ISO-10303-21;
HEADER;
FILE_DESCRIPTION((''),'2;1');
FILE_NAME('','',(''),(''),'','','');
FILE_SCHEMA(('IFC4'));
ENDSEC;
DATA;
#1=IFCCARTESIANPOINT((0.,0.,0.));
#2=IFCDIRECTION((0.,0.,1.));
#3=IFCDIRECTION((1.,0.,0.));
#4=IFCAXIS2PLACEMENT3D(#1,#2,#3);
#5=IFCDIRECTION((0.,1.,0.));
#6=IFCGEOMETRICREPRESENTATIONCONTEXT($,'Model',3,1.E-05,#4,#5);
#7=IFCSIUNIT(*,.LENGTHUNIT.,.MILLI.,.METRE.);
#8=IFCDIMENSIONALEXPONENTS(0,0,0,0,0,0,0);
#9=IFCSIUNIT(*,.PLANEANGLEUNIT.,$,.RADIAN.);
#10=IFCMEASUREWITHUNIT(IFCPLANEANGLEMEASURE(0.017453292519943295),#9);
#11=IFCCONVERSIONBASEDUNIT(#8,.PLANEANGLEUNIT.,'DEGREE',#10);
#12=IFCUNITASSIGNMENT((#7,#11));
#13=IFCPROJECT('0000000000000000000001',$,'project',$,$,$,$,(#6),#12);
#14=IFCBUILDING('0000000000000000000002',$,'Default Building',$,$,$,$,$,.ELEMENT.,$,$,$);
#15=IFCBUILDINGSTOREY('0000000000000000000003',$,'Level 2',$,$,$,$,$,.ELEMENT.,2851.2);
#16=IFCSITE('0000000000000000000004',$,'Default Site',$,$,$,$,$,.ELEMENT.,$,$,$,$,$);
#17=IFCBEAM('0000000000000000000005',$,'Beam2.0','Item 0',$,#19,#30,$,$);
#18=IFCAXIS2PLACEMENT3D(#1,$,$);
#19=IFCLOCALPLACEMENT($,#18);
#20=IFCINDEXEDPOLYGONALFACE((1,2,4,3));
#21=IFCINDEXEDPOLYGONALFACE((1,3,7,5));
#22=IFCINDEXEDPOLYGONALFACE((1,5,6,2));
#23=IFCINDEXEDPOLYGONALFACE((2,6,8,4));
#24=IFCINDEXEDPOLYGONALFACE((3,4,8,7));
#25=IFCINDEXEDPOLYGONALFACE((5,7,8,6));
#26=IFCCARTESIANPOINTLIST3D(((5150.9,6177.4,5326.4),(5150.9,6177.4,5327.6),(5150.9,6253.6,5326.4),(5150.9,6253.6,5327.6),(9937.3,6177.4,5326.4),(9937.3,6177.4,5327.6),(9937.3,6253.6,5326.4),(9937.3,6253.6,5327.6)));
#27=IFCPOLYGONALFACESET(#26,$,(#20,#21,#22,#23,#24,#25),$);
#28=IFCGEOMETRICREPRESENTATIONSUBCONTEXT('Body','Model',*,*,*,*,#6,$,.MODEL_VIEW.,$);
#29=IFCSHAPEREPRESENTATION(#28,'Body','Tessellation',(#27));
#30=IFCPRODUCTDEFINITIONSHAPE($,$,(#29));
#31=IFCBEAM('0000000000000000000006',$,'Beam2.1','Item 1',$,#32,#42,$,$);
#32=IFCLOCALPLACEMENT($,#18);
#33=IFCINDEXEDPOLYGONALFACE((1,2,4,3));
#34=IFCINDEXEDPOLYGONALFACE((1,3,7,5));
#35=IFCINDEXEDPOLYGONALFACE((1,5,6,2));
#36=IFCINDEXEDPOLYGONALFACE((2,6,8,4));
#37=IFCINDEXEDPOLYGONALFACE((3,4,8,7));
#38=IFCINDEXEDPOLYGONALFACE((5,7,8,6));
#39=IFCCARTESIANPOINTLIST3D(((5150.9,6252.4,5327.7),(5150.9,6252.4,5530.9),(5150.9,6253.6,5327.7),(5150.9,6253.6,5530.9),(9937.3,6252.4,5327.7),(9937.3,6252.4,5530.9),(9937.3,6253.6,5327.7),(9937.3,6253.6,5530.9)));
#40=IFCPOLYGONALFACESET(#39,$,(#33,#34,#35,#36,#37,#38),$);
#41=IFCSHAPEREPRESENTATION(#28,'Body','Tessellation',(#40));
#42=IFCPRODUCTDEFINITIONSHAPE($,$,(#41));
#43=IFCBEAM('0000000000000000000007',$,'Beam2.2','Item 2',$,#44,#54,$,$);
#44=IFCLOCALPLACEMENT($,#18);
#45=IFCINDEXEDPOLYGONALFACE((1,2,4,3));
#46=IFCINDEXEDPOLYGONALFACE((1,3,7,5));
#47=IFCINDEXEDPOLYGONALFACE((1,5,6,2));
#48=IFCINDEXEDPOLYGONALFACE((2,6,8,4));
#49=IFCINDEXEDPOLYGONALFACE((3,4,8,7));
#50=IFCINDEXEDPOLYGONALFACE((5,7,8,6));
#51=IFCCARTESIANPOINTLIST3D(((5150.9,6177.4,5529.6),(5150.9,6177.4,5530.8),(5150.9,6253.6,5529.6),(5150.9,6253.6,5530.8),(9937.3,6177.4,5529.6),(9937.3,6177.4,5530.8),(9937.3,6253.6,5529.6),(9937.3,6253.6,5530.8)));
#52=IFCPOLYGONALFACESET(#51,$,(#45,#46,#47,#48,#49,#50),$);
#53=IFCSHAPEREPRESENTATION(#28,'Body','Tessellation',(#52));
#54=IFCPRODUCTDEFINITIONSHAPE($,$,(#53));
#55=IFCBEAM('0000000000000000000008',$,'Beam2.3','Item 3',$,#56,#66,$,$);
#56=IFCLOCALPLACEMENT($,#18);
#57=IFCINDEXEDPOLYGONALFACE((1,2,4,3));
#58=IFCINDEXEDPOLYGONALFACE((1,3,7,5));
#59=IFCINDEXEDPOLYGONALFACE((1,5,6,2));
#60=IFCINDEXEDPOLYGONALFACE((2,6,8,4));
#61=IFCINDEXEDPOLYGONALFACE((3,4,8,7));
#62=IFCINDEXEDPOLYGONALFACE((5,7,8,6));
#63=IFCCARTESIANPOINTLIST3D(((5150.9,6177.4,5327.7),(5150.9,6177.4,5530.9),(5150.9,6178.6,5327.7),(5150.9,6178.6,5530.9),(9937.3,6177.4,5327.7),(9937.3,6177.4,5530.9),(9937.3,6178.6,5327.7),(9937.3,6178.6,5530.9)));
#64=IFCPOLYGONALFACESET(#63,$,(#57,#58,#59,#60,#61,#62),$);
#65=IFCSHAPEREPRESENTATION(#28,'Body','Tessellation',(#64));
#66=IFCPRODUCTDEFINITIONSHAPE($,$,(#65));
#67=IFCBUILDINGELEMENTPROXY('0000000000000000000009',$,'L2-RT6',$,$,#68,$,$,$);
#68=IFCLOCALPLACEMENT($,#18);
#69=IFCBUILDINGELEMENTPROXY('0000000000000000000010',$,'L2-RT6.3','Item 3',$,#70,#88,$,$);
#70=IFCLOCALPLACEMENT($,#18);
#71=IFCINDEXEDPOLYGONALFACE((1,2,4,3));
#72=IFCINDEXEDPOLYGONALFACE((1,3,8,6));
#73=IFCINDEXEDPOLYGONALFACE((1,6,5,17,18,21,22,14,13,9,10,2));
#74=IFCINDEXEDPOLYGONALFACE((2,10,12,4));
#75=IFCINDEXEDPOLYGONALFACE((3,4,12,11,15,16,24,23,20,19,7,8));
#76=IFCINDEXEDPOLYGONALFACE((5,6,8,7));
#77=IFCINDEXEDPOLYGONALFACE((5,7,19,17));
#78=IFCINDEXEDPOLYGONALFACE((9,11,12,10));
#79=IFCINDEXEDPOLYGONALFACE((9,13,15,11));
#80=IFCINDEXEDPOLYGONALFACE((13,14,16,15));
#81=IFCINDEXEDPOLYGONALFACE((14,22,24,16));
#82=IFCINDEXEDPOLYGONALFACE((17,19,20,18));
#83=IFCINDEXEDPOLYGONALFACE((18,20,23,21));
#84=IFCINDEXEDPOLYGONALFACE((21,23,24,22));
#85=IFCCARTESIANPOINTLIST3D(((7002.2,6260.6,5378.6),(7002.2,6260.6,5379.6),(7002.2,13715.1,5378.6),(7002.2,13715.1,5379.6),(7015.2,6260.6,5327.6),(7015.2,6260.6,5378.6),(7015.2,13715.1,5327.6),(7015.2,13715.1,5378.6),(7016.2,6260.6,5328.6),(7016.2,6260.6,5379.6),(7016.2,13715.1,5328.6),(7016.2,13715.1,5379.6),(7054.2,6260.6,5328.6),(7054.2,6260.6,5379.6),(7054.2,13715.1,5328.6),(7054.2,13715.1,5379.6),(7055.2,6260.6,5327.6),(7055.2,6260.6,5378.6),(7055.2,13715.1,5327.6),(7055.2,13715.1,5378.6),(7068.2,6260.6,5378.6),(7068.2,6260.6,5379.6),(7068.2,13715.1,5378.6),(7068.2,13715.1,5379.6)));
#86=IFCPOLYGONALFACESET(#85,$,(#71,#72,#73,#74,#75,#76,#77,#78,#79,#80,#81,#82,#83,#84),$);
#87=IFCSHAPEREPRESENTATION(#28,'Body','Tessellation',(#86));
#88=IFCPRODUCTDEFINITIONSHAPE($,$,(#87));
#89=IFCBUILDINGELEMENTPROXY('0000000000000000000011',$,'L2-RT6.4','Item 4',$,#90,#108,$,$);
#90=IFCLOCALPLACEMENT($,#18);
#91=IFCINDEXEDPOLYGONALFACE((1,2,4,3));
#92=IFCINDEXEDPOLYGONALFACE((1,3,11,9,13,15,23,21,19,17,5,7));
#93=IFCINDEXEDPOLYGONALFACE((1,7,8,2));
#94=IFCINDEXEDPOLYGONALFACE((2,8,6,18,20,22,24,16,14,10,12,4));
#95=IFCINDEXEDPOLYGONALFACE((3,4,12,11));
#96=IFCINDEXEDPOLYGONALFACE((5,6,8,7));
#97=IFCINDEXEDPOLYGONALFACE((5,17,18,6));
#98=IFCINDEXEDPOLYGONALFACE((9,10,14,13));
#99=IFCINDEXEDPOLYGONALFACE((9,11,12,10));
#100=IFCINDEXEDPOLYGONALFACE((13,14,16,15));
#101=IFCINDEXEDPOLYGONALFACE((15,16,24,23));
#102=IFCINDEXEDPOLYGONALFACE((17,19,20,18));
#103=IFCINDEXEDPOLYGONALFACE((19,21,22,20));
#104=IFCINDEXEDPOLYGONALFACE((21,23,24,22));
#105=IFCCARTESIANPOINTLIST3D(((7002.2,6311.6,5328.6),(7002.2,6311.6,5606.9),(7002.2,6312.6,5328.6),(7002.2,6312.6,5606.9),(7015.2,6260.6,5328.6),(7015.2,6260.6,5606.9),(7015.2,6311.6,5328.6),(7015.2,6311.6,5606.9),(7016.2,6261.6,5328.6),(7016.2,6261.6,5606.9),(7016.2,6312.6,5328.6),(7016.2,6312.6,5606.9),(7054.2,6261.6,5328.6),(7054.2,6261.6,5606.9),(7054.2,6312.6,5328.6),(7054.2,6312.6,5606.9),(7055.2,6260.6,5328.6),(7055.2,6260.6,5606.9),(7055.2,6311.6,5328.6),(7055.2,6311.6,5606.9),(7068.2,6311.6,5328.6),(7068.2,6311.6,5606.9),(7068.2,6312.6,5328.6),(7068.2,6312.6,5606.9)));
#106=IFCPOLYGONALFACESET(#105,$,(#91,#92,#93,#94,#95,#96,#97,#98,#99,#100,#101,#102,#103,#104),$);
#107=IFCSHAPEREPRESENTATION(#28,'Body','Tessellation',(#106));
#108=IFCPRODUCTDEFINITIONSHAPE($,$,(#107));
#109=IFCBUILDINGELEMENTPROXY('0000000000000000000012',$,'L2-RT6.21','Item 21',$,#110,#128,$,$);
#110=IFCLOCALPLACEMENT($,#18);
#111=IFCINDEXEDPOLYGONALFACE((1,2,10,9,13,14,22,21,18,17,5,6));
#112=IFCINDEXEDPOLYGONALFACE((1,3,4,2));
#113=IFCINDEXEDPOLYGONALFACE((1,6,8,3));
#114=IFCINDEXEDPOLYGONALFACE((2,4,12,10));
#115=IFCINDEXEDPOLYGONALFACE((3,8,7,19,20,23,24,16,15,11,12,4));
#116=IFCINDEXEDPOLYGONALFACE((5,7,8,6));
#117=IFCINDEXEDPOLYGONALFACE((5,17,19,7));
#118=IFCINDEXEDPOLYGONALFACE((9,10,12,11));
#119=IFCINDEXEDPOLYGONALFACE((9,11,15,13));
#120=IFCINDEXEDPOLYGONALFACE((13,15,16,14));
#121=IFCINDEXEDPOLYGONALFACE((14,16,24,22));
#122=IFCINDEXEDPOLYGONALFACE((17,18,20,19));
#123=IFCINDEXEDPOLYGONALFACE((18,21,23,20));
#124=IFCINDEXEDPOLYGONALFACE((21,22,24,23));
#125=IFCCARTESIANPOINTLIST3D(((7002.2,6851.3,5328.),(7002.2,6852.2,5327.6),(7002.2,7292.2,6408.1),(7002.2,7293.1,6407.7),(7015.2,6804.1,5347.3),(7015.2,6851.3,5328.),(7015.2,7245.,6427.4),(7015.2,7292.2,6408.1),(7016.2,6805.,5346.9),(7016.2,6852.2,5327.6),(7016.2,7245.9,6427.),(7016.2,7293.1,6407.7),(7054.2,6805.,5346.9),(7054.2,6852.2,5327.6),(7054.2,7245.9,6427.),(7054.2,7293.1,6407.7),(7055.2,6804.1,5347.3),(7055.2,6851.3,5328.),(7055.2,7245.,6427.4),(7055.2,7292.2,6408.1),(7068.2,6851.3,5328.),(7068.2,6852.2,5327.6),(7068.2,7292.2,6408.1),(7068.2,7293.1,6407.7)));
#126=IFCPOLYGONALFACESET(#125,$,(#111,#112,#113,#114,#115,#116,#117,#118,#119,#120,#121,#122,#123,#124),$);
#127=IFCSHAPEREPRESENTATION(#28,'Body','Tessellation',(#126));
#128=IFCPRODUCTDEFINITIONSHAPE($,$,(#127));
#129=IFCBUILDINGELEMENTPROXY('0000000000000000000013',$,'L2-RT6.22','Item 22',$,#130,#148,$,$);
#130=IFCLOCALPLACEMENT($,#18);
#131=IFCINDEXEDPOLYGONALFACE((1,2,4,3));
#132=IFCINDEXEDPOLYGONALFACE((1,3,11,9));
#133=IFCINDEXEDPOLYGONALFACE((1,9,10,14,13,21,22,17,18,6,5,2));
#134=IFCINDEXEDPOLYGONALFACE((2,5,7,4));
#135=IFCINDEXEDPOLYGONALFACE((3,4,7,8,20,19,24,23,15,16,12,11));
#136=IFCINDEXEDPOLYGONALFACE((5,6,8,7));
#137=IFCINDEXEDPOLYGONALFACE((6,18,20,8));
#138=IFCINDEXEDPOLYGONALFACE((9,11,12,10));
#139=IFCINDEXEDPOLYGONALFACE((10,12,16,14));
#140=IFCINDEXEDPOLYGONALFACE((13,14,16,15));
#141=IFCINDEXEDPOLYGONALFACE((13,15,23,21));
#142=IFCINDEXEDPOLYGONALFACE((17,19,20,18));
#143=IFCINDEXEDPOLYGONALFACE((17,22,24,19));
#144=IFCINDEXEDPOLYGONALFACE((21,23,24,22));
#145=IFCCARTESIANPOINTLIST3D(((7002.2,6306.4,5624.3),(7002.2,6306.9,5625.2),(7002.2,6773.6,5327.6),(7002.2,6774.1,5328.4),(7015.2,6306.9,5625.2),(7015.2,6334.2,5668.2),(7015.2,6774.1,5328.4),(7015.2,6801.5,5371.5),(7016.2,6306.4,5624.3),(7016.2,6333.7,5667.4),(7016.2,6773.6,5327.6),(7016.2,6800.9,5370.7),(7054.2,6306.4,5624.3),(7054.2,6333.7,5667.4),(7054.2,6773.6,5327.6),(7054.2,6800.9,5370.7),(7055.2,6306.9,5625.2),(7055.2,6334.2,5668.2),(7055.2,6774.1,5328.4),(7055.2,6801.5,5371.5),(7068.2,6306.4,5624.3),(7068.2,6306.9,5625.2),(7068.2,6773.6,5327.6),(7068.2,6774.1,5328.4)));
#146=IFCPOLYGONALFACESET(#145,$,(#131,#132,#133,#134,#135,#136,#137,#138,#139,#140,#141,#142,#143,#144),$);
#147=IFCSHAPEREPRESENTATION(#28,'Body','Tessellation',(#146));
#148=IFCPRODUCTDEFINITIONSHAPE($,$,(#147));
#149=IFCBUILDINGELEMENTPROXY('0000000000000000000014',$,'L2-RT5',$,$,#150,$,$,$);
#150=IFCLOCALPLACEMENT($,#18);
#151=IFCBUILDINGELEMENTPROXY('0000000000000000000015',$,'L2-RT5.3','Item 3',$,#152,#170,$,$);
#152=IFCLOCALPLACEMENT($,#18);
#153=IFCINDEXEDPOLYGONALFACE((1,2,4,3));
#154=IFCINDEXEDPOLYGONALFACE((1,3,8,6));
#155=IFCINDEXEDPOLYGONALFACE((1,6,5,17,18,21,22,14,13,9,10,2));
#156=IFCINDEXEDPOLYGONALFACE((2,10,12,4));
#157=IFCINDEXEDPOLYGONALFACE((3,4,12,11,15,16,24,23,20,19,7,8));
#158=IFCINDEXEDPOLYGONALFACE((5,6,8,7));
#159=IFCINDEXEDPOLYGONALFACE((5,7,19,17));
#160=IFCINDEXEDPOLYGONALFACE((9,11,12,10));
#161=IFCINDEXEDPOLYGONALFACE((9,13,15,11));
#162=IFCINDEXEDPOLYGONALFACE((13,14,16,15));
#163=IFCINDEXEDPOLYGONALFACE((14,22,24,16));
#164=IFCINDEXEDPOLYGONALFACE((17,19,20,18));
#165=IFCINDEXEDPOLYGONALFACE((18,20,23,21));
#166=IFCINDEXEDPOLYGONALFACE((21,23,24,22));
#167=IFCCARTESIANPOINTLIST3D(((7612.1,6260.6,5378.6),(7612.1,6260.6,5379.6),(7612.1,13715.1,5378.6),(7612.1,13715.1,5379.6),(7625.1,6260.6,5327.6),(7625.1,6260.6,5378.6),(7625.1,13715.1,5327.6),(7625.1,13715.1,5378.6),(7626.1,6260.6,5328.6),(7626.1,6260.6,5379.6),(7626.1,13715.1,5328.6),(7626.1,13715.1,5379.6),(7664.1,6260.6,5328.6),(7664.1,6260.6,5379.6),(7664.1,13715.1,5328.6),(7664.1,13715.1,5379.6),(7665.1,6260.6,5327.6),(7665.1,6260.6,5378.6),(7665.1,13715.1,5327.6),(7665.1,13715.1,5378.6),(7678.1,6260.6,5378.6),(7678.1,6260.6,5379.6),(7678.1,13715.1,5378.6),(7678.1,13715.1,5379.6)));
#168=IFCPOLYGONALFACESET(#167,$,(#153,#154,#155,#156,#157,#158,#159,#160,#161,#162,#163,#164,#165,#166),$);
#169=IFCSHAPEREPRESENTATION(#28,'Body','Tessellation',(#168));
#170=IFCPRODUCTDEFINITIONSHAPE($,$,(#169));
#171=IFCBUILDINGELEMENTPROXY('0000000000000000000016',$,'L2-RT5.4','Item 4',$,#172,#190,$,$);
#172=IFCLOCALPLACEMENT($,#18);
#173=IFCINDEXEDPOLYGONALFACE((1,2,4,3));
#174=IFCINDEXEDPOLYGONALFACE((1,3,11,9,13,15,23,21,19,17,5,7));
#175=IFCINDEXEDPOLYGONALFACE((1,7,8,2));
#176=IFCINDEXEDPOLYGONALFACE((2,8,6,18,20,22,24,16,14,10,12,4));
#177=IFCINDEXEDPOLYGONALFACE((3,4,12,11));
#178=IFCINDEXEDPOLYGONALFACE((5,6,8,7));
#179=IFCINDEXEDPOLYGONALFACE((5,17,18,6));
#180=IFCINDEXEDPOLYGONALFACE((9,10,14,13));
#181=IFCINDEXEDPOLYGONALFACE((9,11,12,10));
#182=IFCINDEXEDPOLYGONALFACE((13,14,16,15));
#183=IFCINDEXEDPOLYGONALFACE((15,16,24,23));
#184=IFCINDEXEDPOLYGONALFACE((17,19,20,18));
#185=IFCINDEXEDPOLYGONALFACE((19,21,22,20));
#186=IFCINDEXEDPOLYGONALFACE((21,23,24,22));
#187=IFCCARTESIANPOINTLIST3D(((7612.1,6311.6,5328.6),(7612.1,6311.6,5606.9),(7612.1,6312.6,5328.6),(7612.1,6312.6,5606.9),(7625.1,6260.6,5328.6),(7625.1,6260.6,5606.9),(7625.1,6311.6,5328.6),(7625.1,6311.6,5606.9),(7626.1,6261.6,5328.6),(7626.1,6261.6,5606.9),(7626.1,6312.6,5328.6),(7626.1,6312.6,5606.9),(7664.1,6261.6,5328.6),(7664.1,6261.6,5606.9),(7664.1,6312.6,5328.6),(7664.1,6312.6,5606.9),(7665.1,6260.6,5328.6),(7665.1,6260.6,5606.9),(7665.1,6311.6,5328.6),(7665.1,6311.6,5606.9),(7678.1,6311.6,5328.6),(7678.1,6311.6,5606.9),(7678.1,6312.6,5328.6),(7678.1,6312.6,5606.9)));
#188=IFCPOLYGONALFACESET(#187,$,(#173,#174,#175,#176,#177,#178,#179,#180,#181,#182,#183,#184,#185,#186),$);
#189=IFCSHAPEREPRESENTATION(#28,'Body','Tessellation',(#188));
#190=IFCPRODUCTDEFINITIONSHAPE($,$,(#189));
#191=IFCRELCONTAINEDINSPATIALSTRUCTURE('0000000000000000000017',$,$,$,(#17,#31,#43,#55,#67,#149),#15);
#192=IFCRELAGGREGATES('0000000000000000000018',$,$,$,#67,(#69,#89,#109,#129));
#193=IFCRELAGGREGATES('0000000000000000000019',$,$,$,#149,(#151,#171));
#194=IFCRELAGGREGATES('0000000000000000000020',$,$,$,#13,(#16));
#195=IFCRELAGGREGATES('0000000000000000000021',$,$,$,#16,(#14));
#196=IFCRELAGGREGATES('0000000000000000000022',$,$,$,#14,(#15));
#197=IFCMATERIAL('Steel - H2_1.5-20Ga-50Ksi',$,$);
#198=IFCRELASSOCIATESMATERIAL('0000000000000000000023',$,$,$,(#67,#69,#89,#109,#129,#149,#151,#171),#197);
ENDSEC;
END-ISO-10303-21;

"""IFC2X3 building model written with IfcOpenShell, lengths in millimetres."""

from ifc_helpers import new_model, entity, si_unit, converted_unit, direction, frame, origin, origin_with_axes, place, context, subcontext, project, spatial, polyline, outline, extrude, material, element, aggregate, save


model = new_model("IFC2X3")

# Units and contexts
model_context = context("Model", 3, precision=1e-05, world=origin_with_axes(), true_north=direction((0.0, 1.0, 0.0)))
body_context = subcontext(model_context, "Body", "Model", "MODEL_VIEW")
ifc_project = project(units=[si_unit("LENGTHUNIT", "METRE", prefix="MILLI"), converted_unit("PLANEANGLEUNIT", "DEGREE", entity("IfcPlaneAngleMeasure", 0.017453292519943295), si_unit("PLANEANGLEUNIT", "RADIAN"), dimensions=[0, 0, 0, 0, 0, 0, 0])], contexts=[model_context])

# Site, building, storey
site = spatial("IfcSite", under=ifc_project, Name="Default Site", CompositionType="ELEMENT")
building = spatial("IfcBuilding", under=site, Name="Default Building", CompositionType="ELEMENT")
storey = spatial("IfcBuildingStorey", under=building, Name="Level 2", CompositionType="ELEMENT", Elevation=2851.2)

# Beams
beam_1_placement = place(None, frame((7544.1, 6215.5, 5327.6), z_axis=(0.0, 0.0, -1.0), x_axis=(-1.0, 0.0, 0.0)))
element("IfcBeam", 1, at=beam_1_placement, inside=storey, Name="Beam2.0", Description="Item 0", context=body_context, shape_type="SweptSolid", body=[
    extrude(outline(polyline([(-2393.2, -38.1), (2393.2, -38.1), (2393.2, 38.1), (-2393.2, 38.1), (-2393.2, -38.1)])), origin(), (0.0, 0.0, 1.0), 1.2),
])
beam_2_placement = place(None, frame((7544.1, 6253.6, 5429.3), z_axis=(0.0, -1.0, 0.0), x_axis=(-1.0, 0.0, 0.0)))
element("IfcBeam", 2, at=beam_2_placement, inside=storey, Name="Beam2.1", Description="Item 1", context=body_context, shape_type="SweptSolid", body=[
    extrude(outline(polyline([(-2393.2, -101.6), (2393.2, -101.6), (2393.2, 101.6), (-2393.2, 101.6), (-2393.2, -101.6)])), origin(), (0.0, 0.0, 1.0), 1.2),
])
beam_3_placement = place(None, frame((7544.1, 6215.5, 5530.8), z_axis=(0.0, 0.0, -1.0), x_axis=(-1.0, 0.0, 0.0)))
element("IfcBeam", 3, at=beam_3_placement, inside=storey, Name="Beam2.2", Description="Item 2", context=body_context, shape_type="SweptSolid", body=[
    extrude(outline(polyline([(-2393.2, -38.1), (2393.2, -38.1), (2393.2, 38.1), (-2393.2, 38.1), (-2393.2, -38.1)])), origin(), (0.0, 0.0, 1.0), 1.2),
])
beam_4_placement = place(None, frame((7544.1, 6177.4, 5429.3), z_axis=(0.0, 1.0, 0.0), x_axis=(1.0, 0.0, 0.0)))
element("IfcBeam", 4, at=beam_4_placement, inside=storey, Name="Beam2.3", Description="Item 3", context=body_context, shape_type="SweptSolid", body=[
    extrude(outline(polyline([(-2393.2, -101.6), (2393.2, -101.6), (2393.2, 101.6), (-2393.2, 101.6), (-2393.2, -101.6)])), origin(), (0.0, 0.0, 1.0), 1.2),
])

# Building element proxies
ifc_material = material(Name="Steel - H2_1.5-20Ga-50Ksi")
proxy_1 = element("IfcBuildingElementProxy", 5, inside=storey, material=ifc_material, Name="L2-RT6")
proxy_2_placement = place(None, frame((7002.2, 6260.6, 5379.6), z_axis=(0.0, 1.0, 0.0), x_axis=(40.0, 0.0, 0.0)))
proxy_2 = element("IfcBuildingElementProxy", 6, at=proxy_2_placement, material=ifc_material, Name="L2-RT6.3", Description="Item 3", context=body_context, shape_type="SweptSolid", body=[
    extrude(outline(polyline([(0.0, 0.0), (14.0, 0.0), (14.0, 51.0), (52.0, 51.0), (52.0, 0.0), (66.0, 0.0), (66.0, 1.0), (53.0, 1.0), (53.0, 52.0), (13.0, 52.0), (13.0, 1.0), (0.0, 1.0), (0.0, 0.0)])), origin(), (0.0, 0.0, 1.0), 7454.5),
])
proxy_3_placement = place(None, frame((7002.2, 6312.6, 5606.9), z_axis=(0.0, 0.0, -1.0), x_axis=(40.0, 0.0, 0.0)))
proxy_3 = element("IfcBuildingElementProxy", 7, at=proxy_3_placement, material=ifc_material, Name="L2-RT6.4", Description="Item 4", context=body_context, shape_type="SweptSolid", body=[
    extrude(outline(polyline([(0.0, 0.0), (14.0, 0.0), (14.0, 51.0), (52.0, 51.0), (52.0, 0.0), (66.0, 0.0), (66.0, 1.0), (53.0, 1.0), (53.0, 52.0), (13.0, 52.0), (13.0, 1.0), (0.0, 1.0), (0.0, 0.0)])), origin(), (0.0, 0.0, 1.0), 278.3),
])
proxy_4_placement = place(None, frame((7002.2, 7293.1, 6407.7), z_axis=(0.0, -0.378, -0.926), x_axis=(40.0, 0.0, 0.0)))
proxy_4 = element("IfcBuildingElementProxy", 8, at=proxy_4_placement, material=ifc_material, Name="L2-RT6.21", Description="Item 21", context=body_context, shape_type="SweptSolid", body=[
    extrude(outline(polyline([(0.0, 0.0), (14.0, 0.0), (14.0, 51.0), (52.0, 51.0), (52.0, 0.0), (66.0, 0.0), (66.0, 1.0), (53.0, 1.0), (53.0, 52.0), (13.0, 52.0), (13.0, 1.0), (0.0, 1.0), (0.0, 0.0)])), origin(), (0.0, 0.0, 1.0), 1166.6),
])
proxy_5_placement = place(None, frame((7002.2, 6773.6, 5327.6), z_axis=(0.0, -0.844, 0.536), x_axis=(40.0, 0.0, 0.0)))
proxy_5 = element("IfcBuildingElementProxy", 9, at=proxy_5_placement, material=ifc_material, Name="L2-RT6.22", Description="Item 22", context=body_context, shape_type="SweptSolid", body=[
    extrude(outline(polyline([(0.0, 0.0), (14.0, 0.0), (14.0, 51.0), (52.0, 51.0), (52.0, 0.0), (66.0, 0.0), (66.0, 1.0), (53.0, 1.0), (53.0, 52.0), (13.0, 52.0), (13.0, 1.0), (0.0, 1.0), (0.0, 0.0)])), origin(), (0.0, 0.0, 1.0), 553.5),
])
aggregate(proxy_1, [proxy_2, proxy_3, proxy_4, proxy_5])
proxy_6 = element("IfcBuildingElementProxy", 10, inside=storey, material=ifc_material, Name="L2-RT5")
proxy_7_placement = place(None, frame((7612.1, 6260.6, 5379.6), z_axis=(0.0, 1.0, 0.0), x_axis=(40.0, 0.0, 0.0)))
proxy_7 = element("IfcBuildingElementProxy", 11, at=proxy_7_placement, material=ifc_material, Name="L2-RT5.3", Description="Item 3", context=body_context, shape_type="SweptSolid", body=[
    extrude(outline(polyline([(0.0, 0.0), (14.0, 0.0), (14.0, 51.0), (52.0, 51.0), (52.0, 0.0), (66.0, 0.0), (66.0, 1.0), (53.0, 1.0), (53.0, 52.0), (13.0, 52.0), (13.0, 1.0), (0.0, 1.0), (0.0, 0.0)])), origin(), (0.0, 0.0, 1.0), 7454.5),
])
proxy_8_placement = place(None, frame((7612.1, 6312.6, 5606.9), z_axis=(0.0, 0.0, -1.0), x_axis=(40.0, 0.0, 0.0)))
proxy_8 = element("IfcBuildingElementProxy", 12, at=proxy_8_placement, material=ifc_material, Name="L2-RT5.4", Description="Item 4", context=body_context, shape_type="SweptSolid", body=[
    extrude(outline(polyline([(0.0, 0.0), (14.0, 0.0), (14.0, 51.0), (52.0, 51.0), (52.0, 0.0), (66.0, 0.0), (66.0, 1.0), (53.0, 1.0), (53.0, 52.0), (13.0, 52.0), (13.0, 1.0), (0.0, 1.0), (0.0, 0.0)])), origin(), (0.0, 0.0, 1.0), 278.3),
])
aggregate(proxy_6, [proxy_7, proxy_8])

save(model, "model.ifc")
